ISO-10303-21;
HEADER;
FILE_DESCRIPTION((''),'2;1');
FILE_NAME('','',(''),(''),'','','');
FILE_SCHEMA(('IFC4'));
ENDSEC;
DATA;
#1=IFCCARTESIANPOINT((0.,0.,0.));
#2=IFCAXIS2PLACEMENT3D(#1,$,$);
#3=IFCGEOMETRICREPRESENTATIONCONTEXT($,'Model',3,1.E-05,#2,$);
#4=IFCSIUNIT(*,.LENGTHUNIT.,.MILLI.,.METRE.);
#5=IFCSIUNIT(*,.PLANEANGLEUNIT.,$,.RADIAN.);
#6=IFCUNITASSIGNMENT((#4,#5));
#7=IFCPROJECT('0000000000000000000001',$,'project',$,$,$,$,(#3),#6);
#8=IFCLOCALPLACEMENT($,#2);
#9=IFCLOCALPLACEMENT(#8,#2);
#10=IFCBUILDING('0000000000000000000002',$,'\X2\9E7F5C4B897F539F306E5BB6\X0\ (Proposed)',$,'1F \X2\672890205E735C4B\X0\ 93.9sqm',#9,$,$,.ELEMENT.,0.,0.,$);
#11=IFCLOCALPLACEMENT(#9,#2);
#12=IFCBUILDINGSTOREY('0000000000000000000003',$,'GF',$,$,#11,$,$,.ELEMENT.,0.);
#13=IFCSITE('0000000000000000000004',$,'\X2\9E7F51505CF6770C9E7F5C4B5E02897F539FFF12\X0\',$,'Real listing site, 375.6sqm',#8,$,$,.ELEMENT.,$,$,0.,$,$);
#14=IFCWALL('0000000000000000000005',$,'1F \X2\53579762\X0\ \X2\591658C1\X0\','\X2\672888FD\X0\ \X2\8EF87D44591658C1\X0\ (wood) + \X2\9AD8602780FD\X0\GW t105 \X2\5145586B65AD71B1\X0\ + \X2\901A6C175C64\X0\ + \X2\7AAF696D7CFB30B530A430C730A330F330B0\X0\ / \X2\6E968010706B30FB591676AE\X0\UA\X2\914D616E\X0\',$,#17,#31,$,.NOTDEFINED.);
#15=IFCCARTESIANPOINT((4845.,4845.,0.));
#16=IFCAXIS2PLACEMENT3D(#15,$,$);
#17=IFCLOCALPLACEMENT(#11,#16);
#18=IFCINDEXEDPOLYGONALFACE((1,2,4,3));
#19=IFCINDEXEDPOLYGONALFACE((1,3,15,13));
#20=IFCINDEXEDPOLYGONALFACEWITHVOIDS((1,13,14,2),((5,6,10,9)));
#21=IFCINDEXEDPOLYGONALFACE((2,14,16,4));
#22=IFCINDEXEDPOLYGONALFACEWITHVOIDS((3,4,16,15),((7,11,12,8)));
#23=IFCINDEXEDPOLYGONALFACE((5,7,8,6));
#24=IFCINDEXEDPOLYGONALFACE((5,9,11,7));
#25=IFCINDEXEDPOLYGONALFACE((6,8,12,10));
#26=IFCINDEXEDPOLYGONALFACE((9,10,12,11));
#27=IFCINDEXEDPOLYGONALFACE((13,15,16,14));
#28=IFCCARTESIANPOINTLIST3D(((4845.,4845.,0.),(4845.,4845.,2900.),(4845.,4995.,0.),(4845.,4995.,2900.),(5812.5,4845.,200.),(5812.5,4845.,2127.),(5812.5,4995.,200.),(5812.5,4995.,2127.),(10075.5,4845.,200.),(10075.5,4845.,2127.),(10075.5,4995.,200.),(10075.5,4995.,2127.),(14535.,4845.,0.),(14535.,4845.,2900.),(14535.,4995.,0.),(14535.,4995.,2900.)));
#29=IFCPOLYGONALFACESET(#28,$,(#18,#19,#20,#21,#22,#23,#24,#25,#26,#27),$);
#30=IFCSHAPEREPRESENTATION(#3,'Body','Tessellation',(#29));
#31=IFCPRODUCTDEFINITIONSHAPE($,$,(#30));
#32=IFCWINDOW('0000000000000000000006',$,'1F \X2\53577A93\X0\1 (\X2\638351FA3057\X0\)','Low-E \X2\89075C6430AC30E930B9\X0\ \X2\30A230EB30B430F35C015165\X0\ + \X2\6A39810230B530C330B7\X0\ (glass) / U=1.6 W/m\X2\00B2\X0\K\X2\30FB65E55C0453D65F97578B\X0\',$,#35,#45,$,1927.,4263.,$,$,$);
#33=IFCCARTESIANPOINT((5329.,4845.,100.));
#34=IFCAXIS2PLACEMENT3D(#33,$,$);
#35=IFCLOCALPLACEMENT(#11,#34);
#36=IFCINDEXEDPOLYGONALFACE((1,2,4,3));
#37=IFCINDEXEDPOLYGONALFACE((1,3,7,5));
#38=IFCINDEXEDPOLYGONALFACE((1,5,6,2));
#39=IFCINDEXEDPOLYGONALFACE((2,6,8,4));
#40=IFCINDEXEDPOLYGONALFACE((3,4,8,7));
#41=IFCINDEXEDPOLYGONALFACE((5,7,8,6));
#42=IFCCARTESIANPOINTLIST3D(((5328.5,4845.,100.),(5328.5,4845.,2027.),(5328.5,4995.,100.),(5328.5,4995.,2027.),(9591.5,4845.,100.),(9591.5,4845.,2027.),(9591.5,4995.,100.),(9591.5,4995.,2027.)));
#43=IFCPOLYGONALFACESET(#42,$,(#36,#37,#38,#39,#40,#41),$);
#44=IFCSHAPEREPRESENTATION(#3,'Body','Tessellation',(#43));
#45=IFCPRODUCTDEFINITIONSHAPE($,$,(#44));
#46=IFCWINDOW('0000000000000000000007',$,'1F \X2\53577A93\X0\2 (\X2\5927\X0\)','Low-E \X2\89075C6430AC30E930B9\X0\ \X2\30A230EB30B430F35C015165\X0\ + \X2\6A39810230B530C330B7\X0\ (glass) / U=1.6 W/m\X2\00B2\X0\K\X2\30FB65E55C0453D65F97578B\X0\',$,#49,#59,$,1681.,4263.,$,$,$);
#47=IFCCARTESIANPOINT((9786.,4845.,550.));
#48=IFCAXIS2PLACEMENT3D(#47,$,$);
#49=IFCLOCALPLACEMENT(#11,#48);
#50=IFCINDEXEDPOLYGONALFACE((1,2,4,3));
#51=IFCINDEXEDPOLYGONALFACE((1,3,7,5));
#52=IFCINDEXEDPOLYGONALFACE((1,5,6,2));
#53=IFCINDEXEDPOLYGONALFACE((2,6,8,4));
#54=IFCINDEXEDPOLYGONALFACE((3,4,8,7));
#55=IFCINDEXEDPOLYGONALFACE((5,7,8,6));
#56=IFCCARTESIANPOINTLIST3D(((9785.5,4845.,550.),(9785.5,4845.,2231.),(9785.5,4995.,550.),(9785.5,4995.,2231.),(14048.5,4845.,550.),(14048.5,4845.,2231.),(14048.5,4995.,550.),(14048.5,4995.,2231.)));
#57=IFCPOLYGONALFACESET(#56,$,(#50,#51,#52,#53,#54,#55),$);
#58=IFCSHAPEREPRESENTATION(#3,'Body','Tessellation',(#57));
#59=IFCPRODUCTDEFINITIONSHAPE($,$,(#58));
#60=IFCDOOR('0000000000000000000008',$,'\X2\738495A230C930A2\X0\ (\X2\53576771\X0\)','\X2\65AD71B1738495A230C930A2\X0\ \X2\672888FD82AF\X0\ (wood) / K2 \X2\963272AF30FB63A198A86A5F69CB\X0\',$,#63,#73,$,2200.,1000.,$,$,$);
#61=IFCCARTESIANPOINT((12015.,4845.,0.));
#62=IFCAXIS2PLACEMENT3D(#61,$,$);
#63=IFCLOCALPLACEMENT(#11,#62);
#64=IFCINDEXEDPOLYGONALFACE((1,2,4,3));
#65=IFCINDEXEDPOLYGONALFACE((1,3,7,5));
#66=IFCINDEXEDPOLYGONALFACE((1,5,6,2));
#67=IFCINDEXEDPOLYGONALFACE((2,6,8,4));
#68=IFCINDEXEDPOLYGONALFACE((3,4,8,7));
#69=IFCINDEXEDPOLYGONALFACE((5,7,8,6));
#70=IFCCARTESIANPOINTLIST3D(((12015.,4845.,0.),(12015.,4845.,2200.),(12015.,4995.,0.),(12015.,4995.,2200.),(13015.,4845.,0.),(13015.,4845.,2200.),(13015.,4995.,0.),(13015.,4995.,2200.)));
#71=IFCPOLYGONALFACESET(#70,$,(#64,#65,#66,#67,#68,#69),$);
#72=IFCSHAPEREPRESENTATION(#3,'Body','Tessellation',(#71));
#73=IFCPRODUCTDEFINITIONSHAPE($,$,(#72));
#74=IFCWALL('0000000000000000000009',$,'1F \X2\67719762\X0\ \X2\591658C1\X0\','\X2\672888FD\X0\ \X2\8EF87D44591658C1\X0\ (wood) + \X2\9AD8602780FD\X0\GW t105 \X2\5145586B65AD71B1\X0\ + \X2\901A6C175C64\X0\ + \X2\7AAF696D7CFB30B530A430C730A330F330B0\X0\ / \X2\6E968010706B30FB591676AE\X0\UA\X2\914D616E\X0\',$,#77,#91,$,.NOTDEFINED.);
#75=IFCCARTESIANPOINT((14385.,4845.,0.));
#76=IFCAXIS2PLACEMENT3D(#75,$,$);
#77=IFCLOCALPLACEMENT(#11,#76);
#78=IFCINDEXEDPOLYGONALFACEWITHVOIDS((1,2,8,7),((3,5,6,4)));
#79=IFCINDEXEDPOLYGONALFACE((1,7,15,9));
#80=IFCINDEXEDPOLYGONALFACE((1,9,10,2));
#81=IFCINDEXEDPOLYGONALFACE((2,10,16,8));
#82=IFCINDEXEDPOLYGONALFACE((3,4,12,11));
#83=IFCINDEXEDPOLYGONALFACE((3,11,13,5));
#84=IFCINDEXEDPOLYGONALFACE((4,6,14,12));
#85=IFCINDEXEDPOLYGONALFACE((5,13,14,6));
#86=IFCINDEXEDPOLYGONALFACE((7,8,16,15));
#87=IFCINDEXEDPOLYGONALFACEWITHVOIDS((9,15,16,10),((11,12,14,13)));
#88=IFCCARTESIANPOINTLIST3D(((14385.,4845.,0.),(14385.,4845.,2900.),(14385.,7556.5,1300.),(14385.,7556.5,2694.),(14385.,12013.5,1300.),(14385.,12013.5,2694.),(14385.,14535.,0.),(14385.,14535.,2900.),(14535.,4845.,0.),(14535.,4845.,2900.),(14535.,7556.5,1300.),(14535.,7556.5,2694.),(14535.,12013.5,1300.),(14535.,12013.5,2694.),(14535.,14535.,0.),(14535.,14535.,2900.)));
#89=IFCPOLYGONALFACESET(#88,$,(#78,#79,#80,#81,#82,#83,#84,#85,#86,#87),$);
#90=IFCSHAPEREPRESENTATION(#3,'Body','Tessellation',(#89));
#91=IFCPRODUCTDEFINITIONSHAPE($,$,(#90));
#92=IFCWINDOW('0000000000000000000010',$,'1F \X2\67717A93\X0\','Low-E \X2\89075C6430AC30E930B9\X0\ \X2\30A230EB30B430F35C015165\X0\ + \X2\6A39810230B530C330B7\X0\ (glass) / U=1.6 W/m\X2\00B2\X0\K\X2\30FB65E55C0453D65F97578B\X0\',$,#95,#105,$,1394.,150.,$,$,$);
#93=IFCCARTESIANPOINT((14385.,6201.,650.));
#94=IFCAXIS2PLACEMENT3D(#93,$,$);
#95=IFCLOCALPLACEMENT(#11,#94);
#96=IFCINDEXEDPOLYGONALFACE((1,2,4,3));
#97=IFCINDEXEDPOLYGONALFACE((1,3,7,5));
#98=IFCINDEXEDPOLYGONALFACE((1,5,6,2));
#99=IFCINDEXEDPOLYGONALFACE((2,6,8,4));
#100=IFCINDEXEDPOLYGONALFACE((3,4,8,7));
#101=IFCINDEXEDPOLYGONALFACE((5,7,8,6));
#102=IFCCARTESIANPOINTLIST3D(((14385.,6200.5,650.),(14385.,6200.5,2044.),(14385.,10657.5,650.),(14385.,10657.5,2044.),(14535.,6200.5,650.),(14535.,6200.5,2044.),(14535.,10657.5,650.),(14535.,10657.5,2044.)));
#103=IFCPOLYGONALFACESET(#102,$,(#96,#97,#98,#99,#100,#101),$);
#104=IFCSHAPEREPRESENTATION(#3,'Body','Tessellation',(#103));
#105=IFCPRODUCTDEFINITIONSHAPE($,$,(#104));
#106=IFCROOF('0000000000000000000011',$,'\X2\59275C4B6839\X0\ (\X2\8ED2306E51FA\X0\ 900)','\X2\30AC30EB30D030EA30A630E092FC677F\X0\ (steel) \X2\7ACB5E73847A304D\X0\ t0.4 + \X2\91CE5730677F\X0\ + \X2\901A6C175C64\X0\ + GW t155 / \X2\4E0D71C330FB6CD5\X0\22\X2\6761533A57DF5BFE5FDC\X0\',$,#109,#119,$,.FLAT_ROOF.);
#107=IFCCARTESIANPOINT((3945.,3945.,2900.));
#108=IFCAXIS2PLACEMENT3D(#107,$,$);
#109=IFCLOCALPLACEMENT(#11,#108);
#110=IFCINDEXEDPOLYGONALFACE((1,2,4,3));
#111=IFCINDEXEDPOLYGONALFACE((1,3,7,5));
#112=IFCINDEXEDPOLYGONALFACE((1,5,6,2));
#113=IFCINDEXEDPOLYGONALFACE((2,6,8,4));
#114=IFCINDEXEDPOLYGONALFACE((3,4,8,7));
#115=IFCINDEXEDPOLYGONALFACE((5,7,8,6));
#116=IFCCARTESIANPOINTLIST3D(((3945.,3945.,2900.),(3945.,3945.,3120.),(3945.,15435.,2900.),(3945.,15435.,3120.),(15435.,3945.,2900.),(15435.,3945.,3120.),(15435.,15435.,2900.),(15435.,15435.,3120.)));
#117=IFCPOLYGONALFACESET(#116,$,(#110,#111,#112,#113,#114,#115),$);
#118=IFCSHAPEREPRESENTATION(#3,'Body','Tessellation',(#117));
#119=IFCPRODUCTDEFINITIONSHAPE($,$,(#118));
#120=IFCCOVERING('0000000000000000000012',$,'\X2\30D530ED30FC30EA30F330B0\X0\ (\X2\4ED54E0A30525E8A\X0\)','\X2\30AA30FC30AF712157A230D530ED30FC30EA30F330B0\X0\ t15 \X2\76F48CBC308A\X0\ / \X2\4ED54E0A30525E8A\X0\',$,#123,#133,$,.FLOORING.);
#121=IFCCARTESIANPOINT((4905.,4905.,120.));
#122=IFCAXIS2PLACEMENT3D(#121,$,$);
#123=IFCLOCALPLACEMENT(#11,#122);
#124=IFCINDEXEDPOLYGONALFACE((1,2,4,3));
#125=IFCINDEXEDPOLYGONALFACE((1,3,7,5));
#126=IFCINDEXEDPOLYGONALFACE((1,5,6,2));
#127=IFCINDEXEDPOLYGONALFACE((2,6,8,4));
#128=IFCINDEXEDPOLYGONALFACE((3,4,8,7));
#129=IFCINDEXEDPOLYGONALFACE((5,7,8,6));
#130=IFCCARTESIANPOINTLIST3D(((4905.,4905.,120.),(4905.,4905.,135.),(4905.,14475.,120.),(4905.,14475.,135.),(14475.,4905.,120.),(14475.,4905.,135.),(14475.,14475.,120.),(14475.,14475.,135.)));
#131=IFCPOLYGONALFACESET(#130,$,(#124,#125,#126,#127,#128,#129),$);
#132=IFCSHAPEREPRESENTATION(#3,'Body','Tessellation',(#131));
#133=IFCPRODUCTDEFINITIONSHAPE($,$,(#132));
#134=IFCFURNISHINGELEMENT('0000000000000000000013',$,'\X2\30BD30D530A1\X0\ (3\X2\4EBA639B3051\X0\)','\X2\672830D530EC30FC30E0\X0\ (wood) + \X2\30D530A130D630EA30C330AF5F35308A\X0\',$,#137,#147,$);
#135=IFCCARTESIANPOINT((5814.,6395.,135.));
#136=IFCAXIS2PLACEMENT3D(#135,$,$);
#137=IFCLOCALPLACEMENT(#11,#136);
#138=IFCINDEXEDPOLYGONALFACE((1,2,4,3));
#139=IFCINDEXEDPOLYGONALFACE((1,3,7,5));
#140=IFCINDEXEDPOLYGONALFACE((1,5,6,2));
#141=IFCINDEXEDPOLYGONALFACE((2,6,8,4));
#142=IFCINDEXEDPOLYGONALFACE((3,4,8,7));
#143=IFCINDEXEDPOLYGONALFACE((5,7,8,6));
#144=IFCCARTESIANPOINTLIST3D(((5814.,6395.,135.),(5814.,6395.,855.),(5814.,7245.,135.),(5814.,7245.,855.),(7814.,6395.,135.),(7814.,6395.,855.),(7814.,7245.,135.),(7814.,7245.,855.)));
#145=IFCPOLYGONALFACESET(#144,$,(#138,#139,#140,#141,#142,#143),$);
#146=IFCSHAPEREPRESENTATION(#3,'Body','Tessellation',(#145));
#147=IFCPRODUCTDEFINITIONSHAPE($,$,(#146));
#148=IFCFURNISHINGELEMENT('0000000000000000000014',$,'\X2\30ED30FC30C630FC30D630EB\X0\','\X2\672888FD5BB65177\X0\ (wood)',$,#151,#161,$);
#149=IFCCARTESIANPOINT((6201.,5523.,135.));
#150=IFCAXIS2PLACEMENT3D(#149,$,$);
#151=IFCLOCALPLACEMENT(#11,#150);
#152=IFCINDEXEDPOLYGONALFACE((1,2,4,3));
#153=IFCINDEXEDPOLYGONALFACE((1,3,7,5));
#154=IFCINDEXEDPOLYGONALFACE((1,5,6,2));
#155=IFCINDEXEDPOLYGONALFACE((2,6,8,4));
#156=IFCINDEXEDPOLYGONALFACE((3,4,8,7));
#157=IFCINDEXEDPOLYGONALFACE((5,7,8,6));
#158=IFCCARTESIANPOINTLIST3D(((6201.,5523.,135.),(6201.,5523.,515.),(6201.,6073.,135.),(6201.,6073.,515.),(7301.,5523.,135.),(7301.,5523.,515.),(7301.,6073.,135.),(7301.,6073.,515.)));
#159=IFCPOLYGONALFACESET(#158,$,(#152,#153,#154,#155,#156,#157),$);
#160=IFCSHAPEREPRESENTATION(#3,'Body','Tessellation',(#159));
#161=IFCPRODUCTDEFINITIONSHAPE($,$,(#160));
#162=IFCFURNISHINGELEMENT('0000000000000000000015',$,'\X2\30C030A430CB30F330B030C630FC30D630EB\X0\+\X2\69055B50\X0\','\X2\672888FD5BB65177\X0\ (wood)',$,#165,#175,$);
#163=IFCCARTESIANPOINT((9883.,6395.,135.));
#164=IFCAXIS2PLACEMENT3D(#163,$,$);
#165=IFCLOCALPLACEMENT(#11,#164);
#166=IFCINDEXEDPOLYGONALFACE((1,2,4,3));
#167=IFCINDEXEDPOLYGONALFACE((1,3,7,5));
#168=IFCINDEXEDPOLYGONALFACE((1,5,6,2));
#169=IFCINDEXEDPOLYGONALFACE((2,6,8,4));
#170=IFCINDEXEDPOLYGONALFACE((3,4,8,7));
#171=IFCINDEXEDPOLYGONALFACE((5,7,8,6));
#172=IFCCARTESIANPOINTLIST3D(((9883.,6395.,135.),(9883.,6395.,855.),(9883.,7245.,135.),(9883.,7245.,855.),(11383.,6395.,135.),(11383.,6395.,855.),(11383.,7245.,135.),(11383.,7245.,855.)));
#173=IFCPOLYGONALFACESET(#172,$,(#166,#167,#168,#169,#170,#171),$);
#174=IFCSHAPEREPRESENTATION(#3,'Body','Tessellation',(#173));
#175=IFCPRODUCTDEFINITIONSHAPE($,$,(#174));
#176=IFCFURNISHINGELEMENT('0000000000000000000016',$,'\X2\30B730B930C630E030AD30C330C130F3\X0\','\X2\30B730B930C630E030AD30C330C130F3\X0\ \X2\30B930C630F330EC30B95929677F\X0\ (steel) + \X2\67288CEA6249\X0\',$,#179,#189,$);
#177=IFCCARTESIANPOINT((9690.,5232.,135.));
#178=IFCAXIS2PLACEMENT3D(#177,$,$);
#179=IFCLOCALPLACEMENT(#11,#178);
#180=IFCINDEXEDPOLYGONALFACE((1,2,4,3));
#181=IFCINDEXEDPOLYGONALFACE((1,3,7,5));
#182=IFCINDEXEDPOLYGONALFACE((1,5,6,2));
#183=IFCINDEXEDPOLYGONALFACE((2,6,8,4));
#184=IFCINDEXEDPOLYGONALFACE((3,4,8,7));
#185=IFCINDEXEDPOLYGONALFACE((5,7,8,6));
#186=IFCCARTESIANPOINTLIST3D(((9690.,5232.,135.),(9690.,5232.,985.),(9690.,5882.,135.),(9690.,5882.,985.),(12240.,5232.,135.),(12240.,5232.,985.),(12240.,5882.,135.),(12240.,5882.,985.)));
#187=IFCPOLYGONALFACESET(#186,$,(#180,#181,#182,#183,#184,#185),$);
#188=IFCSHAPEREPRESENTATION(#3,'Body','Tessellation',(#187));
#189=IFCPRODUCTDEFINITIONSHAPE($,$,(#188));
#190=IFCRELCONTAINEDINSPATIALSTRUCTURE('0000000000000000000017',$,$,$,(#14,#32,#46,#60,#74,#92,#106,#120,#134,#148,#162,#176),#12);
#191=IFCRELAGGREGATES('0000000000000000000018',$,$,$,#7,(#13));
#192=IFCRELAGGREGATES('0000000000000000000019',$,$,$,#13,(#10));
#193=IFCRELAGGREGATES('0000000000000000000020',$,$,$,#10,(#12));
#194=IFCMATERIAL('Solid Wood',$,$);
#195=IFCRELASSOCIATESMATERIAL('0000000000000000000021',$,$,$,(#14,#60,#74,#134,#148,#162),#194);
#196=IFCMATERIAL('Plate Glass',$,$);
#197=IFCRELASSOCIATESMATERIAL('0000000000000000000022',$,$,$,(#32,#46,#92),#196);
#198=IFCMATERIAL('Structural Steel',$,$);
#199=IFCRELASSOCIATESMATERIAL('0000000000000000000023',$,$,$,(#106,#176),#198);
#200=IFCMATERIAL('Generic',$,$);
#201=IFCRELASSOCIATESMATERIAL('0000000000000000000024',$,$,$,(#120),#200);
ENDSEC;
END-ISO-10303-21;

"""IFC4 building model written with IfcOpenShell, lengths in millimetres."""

from ifc_helpers import new_model, si_unit, frame, frame_2d, origin, place, context, project, spatial, rectangle, extrude, material, element, fill, save


model = new_model("IFC4")

# Units and contexts
model_context = context("Model", 3, precision=1e-05, world=origin())
ifc_project = project(units=[si_unit("LENGTHUNIT", "METRE", prefix="MILLI"), si_unit("PLANEANGLEUNIT", "RADIAN")], contexts=[model_context])

# Site, building, storey
site_placement = place(None, origin())
site = spatial("IfcSite", under=ifc_project, at=site_placement, Name="鹿児島県鹿屋市西原２", ObjectType="Real listing site, 375.6sqm", CompositionType="ELEMENT", RefElevation=0.0)
building_placement = place(site_placement, origin())
building = spatial("IfcBuilding", under=site, at=building_placement, Name="鹿屋西原の家 (Proposed)", ObjectType="1F 木造平屋 93.9sqm", CompositionType="ELEMENT", ElevationOfRefHeight=0.0, ElevationOfTerrain=0.0)
storey_placement = place(building_placement, origin())
storey = spatial("IfcBuildingStorey", under=building, at=storey_placement, Name="GF", CompositionType="ELEMENT", Elevation=0.0)

# Shared definitions
ifc_material_1 = material(Name="Solid Wood")

# Wall, openings, windows, door
wall_1_placement = place(storey_placement, frame((4845.0, 4845.0, 0.0)))
wall_1 = element("IfcWall", 1, at=wall_1_placement, inside=storey, material=ifc_material_1, Name="1F 南面 外壁", Description="木製 軸組外壁 (wood) + 高性能GW t105 充填断熱 + 通気層 + 窯業系サイディング / 準耐火・外皮UA配慮", PredefinedType="NOTDEFINED", context=model_context, shape_type="SweptSolid", body=[
    extrude(rectangle(XDim=9690.0, YDim=150.0, at=frame_2d((4845.0, 75.0))), frame((4845.0, 4845.0, 0.0)), (0.0, 0.0, 1.0), 2900.0),
])
opening_1_placement = place(storey_placement, frame((5329.0, 4845.0, 100.0)))
opening_1 = element("IfcOpeningElement", 2, at=opening_1_placement, cuts=wall_1, PredefinedType="NOTDEFINED", context=model_context, shape_type="SweptSolid", body=[
    extrude(rectangle(XDim=4263.0, YDim=150.0, at=frame_2d((2131.0, 75.0))), frame((5329.0, 4845.0, 100.0)), (0.0, 0.0, 1.0), 1927.0),
])
opening_2_placement = place(storey_placement, frame((9786.0, 4845.0, 550.0)))
opening_2 = element("IfcOpeningElement", 3, at=opening_2_placement, cuts=wall_1, PredefinedType="NOTDEFINED", context=model_context, shape_type="SweptSolid", body=[
    extrude(rectangle(XDim=4263.0, YDim=150.0, at=frame_2d((2131.0, 75.0))), frame((9786.0, 4845.0, 550.0)), (0.0, 0.0, 1.0), 1681.0),
])
opening_3_placement = place(storey_placement, frame((12015.0, 4845.0, 0.0)))
opening_3 = element("IfcOpeningElement", 4, at=opening_3_placement, cuts=wall_1, PredefinedType="NOTDEFINED", context=model_context, shape_type="SweptSolid", body=[
    extrude(rectangle(XDim=1000.0, YDim=150.0, at=frame_2d((500.0, 75.0))), frame((12015.0, 4845.0, 0.0)), (0.0, 0.0, 1.0), 2200.0),
])
ifc_material_2 = material(Name="Plate Glass")
window_1_placement = place(storey_placement, frame((5329.0, 4845.0, 100.0)))
window_1 = element("IfcWindow", 5, at=window_1_placement, inside=storey, material=ifc_material_2, Name="1F 南窓1 (掃出し)", Description="Low-E 複層ガラス アルゴン封入 + 樹脂サッシ (glass) / U=1.6 W/m²K・日射取得型", OverallHeight=1927.0, OverallWidth=4263.0, context=model_context, shape_type="SweptSolid", body=[
    extrude(rectangle(XDim=4263.0, YDim=150.0, at=frame_2d((2131.0, 75.0))), frame((5329.0, 4845.0, 100.0)), (0.0, 0.0, 1.0), 1927.0),
])
fill(opening_1, window_1)
window_2_placement = place(storey_placement, frame((9786.0, 4845.0, 550.0)))
window_2 = element("IfcWindow", 6, at=window_2_placement, inside=storey, material=ifc_material_2, Name="1F 南窓2 (大)", Description="Low-E 複層ガラス アルゴン封入 + 樹脂サッシ (glass) / U=1.6 W/m²K・日射取得型", OverallHeight=1681.0, OverallWidth=4263.0, context=model_context, shape_type="SweptSolid", body=[
    extrude(rectangle(XDim=4263.0, YDim=150.0, at=frame_2d((2131.0, 75.0))), frame((9786.0, 4845.0, 550.0)), (0.0, 0.0, 1.0), 1681.0),
])
fill(opening_2, window_2)
door_placement = place(storey_placement, frame((12015.0, 4845.0, 0.0)))
door = element("IfcDoor", 7, at=door_placement, inside=storey, material=ifc_material_1, Name="玄関ドア (南東)", Description="断熱玄関ドア 木製芯 (wood) / K2 防犯・採風機構", OverallHeight=2200.0, OverallWidth=1000.0, context=model_context, shape_type="SweptSolid", body=[
    extrude(rectangle(XDim=1000.0, YDim=150.0, at=frame_2d((500.0, 75.0))), frame((12015.0, 4845.0, 0.0)), (0.0, 0.0, 1.0), 2200.0),
])
fill(opening_3, door)

# Wall, opening, window
wall_2_placement = place(storey_placement, frame((14385.0, 4845.0, 0.0)))
wall_2 = element("IfcWall", 8, at=wall_2_placement, inside=storey, material=ifc_material_1, Name="1F 東面 外壁", Description="木製 軸組外壁 (wood) + 高性能GW t105 充填断熱 + 通気層 + 窯業系サイディング / 準耐火・外皮UA配慮", PredefinedType="NOTDEFINED", context=model_context, shape_type="SweptSolid", body=[
    extrude(rectangle(XDim=150.0, YDim=9690.0, at=frame_2d((75.0, 4845.0))), frame((14385.0, 4845.0, 0.0)), (0.0, 0.0, 1.0), 2900.0),
])
opening_4_placement = place(storey_placement, frame((14385.0, 6201.0, 650.0)))
opening_4 = element("IfcOpeningElement", 9, at=opening_4_placement, cuts=wall_2, PredefinedType="NOTDEFINED", context=model_context, shape_type="SweptSolid", body=[
    extrude(rectangle(XDim=150.0, YDim=4457.0, at=frame_2d((75.0, 2228.0))), frame((14385.0, 6201.0, 650.0)), (0.0, 0.0, 1.0), 1394.0),
])
window_3_placement = place(storey_placement, frame((14385.0, 6201.0, 650.0)))
window_3 = element("IfcWindow", 10, at=window_3_placement, inside=storey, material=ifc_material_2, Name="1F 東窓", Description="Low-E 複層ガラス アルゴン封入 + 樹脂サッシ (glass) / U=1.6 W/m²K・日射取得型", OverallHeight=1394.0, OverallWidth=150.0, context=model_context, shape_type="SweptSolid", body=[
    extrude(rectangle(XDim=150.0, YDim=4457.0, at=frame_2d((75.0, 2228.0))), frame((14385.0, 6201.0, 650.0)), (0.0, 0.0, 1.0), 1394.0),
])
fill(opening_4, window_3)

# Roof
ifc_material_3 = material(Name="Structural Steel")
roof_placement = place(storey_placement, frame((3945.0, 3945.0, 2900.0)))
element("IfcRoof", 11, at=roof_placement, inside=storey, material=ifc_material_3, Name="大屋根 (軒の出 900)", Description="ガルバリウム鋼板 (steel) 立平葺き t0.4 + 野地板 + 通気層 + GW t155 / 不燃・法22条区域対応", PredefinedType="FLAT_ROOF", context=model_context, shape_type="SweptSolid", body=[
    extrude(rectangle(XDim=11490.0, YDim=11490.0, at=frame_2d((5745.0, 5745.0))), frame((3945.0, 3945.0, 2900.0)), (0.0, 0.0, 1.0), 220.0),
])

# Covering
ifc_material_4 = material(Name="Generic")
covering_placement = place(storey_placement, frame((4905.0, 4905.0, 120.0)))
element("IfcCovering", 12, at=covering_placement, inside=storey, material=ifc_material_4, Name="フローリング (仕上げ床)", Description="オーク無垢フローリング t15 直貼り / 仕上げ床", PredefinedType="FLOORING", context=model_context, shape_type="SweptSolid", body=[
    extrude(rectangle(XDim=9570.0, YDim=9570.0, at=frame_2d((4785.0, 4785.0))), frame((4905.0, 4905.0, 120.0)), (0.0, 0.0, 1.0), 15.0),
])

# Furnishing elements
furnishing_1_placement = place(storey_placement, frame((5814.0, 6395.0, 135.0)))
element("IfcFurnishingElement", 13, at=furnishing_1_placement, inside=storey, material=ifc_material_1, Name="ソファ (3人掛け)", Description="木フレーム (wood) + ファブリック張り", context=model_context, shape_type="SweptSolid", body=[
    extrude(rectangle(XDim=2000.0, YDim=850.0, at=frame_2d((1000.0, 425.0))), frame((5814.0, 6395.0, 135.0)), (0.0, 0.0, 1.0), 720.0),
])
furnishing_2_placement = place(storey_placement, frame((6201.0, 5523.0, 135.0)))
element("IfcFurnishingElement", 14, at=furnishing_2_placement, inside=storey, material=ifc_material_1, Name="ローテーブル", Description="木製家具 (wood)", context=model_context, shape_type="SweptSolid", body=[
    extrude(rectangle(XDim=1100.0, YDim=550.0, at=frame_2d((550.0, 275.0))), frame((6201.0, 5523.0, 135.0)), (0.0, 0.0, 1.0), 380.0),
])
furnishing_3_placement = place(storey_placement, frame((9883.0, 6395.0, 135.0)))
element("IfcFurnishingElement", 15, at=furnishing_3_placement, inside=storey, material=ifc_material_1, Name="ダイニングテーブル+椅子", Description="木製家具 (wood)", context=model_context, shape_type="SweptSolid", body=[
    extrude(rectangle(XDim=1500.0, YDim=850.0, at=frame_2d((750.0, 425.0))), frame((9883.0, 6395.0, 135.0)), (0.0, 0.0, 1.0), 720.0),
])
furnishing_4_placement = place(storey_placement, frame((9690.0, 5232.0, 135.0)))
element("IfcFurnishingElement", 16, at=furnishing_4_placement, inside=storey, material=ifc_material_3, Name="システムキッチン", Description="システムキッチン ステンレス天板 (steel) + 木質扉", context=model_context, shape_type="SweptSolid", body=[
    extrude(rectangle(XDim=2550.0, YDim=650.0, at=frame_2d((1275.0, 325.0))), frame((9690.0, 5232.0, 135.0)), (0.0, 0.0, 1.0), 850.0),
])

save(model, "model.ifc")
